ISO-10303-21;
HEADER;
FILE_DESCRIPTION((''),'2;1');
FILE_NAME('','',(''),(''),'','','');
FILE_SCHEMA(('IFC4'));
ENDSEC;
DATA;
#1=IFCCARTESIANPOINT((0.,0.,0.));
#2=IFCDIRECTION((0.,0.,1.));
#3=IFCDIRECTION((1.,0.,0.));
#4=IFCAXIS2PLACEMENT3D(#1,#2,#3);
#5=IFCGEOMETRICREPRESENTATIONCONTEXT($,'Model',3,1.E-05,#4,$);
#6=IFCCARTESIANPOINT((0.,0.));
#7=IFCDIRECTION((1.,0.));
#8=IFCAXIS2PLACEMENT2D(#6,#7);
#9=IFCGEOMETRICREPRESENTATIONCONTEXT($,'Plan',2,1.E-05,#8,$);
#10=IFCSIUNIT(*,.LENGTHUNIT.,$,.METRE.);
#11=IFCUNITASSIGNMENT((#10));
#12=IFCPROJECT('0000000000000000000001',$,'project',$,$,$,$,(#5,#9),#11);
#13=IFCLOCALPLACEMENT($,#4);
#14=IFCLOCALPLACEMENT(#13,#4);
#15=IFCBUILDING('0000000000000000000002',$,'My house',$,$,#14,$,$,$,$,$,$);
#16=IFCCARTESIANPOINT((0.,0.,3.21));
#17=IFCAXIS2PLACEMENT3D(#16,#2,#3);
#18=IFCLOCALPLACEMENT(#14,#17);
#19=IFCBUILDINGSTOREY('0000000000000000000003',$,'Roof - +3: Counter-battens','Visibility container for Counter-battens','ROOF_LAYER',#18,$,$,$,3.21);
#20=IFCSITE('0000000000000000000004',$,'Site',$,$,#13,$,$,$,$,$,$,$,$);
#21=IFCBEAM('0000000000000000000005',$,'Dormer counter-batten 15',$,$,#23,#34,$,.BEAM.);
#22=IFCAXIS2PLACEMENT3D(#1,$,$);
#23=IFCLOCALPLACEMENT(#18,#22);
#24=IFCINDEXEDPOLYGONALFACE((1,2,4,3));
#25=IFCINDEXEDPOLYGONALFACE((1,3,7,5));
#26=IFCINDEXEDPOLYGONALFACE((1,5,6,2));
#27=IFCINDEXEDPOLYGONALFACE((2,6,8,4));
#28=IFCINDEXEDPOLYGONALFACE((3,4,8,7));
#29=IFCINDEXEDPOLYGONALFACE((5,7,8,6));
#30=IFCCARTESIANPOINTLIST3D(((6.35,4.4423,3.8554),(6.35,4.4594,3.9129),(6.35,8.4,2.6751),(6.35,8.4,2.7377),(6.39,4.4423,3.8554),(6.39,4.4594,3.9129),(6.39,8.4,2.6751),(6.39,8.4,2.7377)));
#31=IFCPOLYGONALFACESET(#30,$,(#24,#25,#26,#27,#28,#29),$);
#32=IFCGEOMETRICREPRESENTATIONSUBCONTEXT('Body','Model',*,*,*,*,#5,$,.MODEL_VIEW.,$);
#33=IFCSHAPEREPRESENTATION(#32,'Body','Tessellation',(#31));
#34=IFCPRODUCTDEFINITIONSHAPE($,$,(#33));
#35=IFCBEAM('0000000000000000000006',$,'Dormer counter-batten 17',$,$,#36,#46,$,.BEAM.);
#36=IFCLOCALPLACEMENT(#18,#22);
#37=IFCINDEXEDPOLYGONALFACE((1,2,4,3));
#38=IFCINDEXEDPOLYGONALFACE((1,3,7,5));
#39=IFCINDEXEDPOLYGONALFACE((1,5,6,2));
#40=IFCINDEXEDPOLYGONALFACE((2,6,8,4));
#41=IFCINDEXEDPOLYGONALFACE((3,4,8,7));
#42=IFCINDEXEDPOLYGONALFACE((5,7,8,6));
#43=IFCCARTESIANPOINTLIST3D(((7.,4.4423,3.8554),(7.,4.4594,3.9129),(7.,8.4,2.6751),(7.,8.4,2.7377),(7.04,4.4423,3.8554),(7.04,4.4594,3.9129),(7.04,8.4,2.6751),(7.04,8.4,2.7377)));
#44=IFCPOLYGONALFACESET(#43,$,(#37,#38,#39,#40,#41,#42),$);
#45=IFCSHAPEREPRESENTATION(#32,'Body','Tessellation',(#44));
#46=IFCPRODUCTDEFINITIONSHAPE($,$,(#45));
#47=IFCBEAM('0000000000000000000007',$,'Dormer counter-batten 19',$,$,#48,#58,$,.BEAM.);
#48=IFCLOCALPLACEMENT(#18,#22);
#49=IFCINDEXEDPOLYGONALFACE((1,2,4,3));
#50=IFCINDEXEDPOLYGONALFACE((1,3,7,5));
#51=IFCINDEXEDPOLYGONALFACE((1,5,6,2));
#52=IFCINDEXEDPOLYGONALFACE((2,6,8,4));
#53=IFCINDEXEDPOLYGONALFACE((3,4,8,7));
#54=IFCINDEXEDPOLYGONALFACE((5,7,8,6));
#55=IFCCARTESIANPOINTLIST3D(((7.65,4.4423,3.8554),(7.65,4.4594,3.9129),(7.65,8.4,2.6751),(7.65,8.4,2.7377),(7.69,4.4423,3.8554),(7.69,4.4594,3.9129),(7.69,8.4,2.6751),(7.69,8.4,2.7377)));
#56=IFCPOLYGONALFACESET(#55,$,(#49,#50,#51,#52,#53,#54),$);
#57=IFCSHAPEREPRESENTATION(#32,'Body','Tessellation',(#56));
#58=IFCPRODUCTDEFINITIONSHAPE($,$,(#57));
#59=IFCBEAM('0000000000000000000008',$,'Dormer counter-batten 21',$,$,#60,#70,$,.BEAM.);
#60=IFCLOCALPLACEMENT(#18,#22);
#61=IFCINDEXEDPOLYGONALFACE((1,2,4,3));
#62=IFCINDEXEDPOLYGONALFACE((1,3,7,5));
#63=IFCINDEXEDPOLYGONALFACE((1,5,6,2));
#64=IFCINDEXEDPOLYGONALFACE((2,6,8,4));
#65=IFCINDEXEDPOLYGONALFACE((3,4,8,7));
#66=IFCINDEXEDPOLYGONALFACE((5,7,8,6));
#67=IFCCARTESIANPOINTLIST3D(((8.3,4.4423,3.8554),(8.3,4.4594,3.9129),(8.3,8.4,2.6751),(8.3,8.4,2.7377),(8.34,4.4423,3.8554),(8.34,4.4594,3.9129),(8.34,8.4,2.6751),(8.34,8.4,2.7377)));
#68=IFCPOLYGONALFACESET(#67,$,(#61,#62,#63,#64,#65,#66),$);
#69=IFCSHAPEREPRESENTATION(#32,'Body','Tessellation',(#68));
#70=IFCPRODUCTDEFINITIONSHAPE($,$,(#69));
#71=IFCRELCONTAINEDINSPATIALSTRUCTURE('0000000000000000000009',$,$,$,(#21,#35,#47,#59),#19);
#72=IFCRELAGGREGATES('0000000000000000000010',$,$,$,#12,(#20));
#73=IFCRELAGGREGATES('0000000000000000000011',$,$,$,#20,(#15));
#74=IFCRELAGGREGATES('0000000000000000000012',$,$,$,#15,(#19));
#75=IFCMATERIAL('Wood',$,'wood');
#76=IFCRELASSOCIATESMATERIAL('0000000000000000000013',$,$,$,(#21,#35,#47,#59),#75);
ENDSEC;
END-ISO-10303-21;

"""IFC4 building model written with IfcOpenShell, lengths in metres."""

from ifc_helpers import new_model, si_unit, frame, origin_with_axes, origin_2d_with_axis, place, context, subcontext, project, spatial, rectangle, extrude, clip, halfspace, material, element, save


model = new_model("IFC4")

# Units and contexts
model_context = context("Model", 3, precision=1e-05, world=origin_with_axes())
plan_context = context("Plan", 2, precision=1e-05, world=origin_2d_with_axis())
body_context = subcontext(model_context, "Body", "Model", "MODEL_VIEW")
ifc_project = project(units=[si_unit("LENGTHUNIT", "METRE")], contexts=[model_context, plan_context])

# Site, building, storey
site_placement = place(None, origin_with_axes())
site = spatial("IfcSite", under=ifc_project, at=site_placement, Name="Site")
building_placement = place(site_placement, origin_with_axes())
building = spatial("IfcBuilding", under=site, at=building_placement, Name="My house")
storey_placement = place(building_placement, frame((0.0, 0.0, 3.21), z_axis=(0.0, 0.0, 1.0), x_axis=(1.0, 0.0, 0.0)))
storey = spatial("IfcBuildingStorey", under=building, at=storey_placement, Name="Roof - +3: Counter-battens", Description="Visibility container for Counter-battens", ObjectType="ROOF_LAYER", Elevation=3.21)

# Beams
ifc_material = material(Name="Wood", Category="wood")
beam_1_placement = place(storey_placement, frame((6.37, 4.4509, 3.8841), z_axis=(0.0, 0.28578, 0.958295), x_axis=(0.0, 0.958295, -0.28578)))
element("IfcBeam", 1, at=beam_1_placement, inside=storey, material=ifc_material, Name="Dormer counter-batten 15", PredefinedType="BEAM", context=body_context, shape_type="Clipping", body=[
    clip(clip(extrude(rectangle(XDim=0.04, YDim=0.06), frame((0.0, 0.0, 0.0), z_axis=(1.0, 0.0, 0.0), x_axis=(0.0, 1.0, 0.0)), (0.0, 0.0, 1.0), 5.5), halfspace(frame((1.5953, 6.37, -6.9271), z_axis=(-0.958295, 0.0, -0.28578), x_axis=(0.0, 1.0, 0.0)), False)), halfspace(frame((5.8118, 6.37, -5.6697), z_axis=(0.958295, 0.0, 0.28578), x_axis=(0.0, -1.0, 0.0)), False)),
])
beam_2_placement = place(storey_placement, frame((7.02, 4.4509, 3.8841), z_axis=(0.0, 0.28578, 0.958295), x_axis=(0.0, 0.958295, -0.28578)))
element("IfcBeam", 2, at=beam_2_placement, inside=storey, material=ifc_material, Name="Dormer counter-batten 17", PredefinedType="BEAM", context=body_context, shape_type="Clipping", body=[
    clip(clip(extrude(rectangle(XDim=0.04, YDim=0.06), frame((0.0, 0.0, 0.0), z_axis=(1.0, 0.0, 0.0), x_axis=(0.0, 1.0, 0.0)), (0.0, 0.0, 1.0), 5.5), halfspace(frame((1.5953, 7.02, -6.9271), z_axis=(-0.958295, 0.0, -0.28578), x_axis=(0.0, 1.0, 0.0)), False)), halfspace(frame((5.8118, 7.02, -5.6697), z_axis=(0.958295, 0.0, 0.28578), x_axis=(0.0, -1.0, 0.0)), False)),
])
beam_3_placement = place(storey_placement, frame((7.67, 4.4509, 3.8841), z_axis=(0.0, 0.28578, 0.958295), x_axis=(0.0, 0.958295, -0.28578)))
element("IfcBeam", 3, at=beam_3_placement, inside=storey, material=ifc_material, Name="Dormer counter-batten 19", PredefinedType="BEAM", context=body_context, shape_type="Clipping", body=[
    clip(clip(extrude(rectangle(XDim=0.04, YDim=0.06), frame((0.0, 0.0, 0.0), z_axis=(1.0, 0.0, 0.0), x_axis=(0.0, 1.0, 0.0)), (0.0, 0.0, 1.0), 5.5), halfspace(frame((1.5953, 7.67, -6.9271), z_axis=(-0.958295, 0.0, -0.28578), x_axis=(0.0, 1.0, 0.0)), False)), halfspace(frame((5.8118, 7.67, -5.6697), z_axis=(0.958295, 0.0, 0.28578), x_axis=(0.0, -1.0, 0.0)), False)),
])
beam_4_placement = place(storey_placement, frame((8.32, 4.4509, 3.8841), z_axis=(0.0, 0.28578, 0.958295), x_axis=(0.0, 0.958295, -0.28578)))
element("IfcBeam", 4, at=beam_4_placement, inside=storey, material=ifc_material, Name="Dormer counter-batten 21", PredefinedType="BEAM", context=body_context, shape_type="Clipping", body=[
    clip(clip(extrude(rectangle(XDim=0.04, YDim=0.06), frame((0.0, 0.0, 0.0), z_axis=(1.0, 0.0, 0.0), x_axis=(0.0, 1.0, 0.0)), (0.0, 0.0, 1.0), 5.5), halfspace(frame((1.5953, 8.32, -6.9271), z_axis=(-0.958295, 0.0, -0.28578), x_axis=(0.0, 1.0, 0.0)), False)), halfspace(frame((5.8118, 8.32, -5.6697), z_axis=(0.958295, 0.0, 0.28578), x_axis=(0.0, -1.0, 0.0)), False)),
])

save(model, "model.ifc")
